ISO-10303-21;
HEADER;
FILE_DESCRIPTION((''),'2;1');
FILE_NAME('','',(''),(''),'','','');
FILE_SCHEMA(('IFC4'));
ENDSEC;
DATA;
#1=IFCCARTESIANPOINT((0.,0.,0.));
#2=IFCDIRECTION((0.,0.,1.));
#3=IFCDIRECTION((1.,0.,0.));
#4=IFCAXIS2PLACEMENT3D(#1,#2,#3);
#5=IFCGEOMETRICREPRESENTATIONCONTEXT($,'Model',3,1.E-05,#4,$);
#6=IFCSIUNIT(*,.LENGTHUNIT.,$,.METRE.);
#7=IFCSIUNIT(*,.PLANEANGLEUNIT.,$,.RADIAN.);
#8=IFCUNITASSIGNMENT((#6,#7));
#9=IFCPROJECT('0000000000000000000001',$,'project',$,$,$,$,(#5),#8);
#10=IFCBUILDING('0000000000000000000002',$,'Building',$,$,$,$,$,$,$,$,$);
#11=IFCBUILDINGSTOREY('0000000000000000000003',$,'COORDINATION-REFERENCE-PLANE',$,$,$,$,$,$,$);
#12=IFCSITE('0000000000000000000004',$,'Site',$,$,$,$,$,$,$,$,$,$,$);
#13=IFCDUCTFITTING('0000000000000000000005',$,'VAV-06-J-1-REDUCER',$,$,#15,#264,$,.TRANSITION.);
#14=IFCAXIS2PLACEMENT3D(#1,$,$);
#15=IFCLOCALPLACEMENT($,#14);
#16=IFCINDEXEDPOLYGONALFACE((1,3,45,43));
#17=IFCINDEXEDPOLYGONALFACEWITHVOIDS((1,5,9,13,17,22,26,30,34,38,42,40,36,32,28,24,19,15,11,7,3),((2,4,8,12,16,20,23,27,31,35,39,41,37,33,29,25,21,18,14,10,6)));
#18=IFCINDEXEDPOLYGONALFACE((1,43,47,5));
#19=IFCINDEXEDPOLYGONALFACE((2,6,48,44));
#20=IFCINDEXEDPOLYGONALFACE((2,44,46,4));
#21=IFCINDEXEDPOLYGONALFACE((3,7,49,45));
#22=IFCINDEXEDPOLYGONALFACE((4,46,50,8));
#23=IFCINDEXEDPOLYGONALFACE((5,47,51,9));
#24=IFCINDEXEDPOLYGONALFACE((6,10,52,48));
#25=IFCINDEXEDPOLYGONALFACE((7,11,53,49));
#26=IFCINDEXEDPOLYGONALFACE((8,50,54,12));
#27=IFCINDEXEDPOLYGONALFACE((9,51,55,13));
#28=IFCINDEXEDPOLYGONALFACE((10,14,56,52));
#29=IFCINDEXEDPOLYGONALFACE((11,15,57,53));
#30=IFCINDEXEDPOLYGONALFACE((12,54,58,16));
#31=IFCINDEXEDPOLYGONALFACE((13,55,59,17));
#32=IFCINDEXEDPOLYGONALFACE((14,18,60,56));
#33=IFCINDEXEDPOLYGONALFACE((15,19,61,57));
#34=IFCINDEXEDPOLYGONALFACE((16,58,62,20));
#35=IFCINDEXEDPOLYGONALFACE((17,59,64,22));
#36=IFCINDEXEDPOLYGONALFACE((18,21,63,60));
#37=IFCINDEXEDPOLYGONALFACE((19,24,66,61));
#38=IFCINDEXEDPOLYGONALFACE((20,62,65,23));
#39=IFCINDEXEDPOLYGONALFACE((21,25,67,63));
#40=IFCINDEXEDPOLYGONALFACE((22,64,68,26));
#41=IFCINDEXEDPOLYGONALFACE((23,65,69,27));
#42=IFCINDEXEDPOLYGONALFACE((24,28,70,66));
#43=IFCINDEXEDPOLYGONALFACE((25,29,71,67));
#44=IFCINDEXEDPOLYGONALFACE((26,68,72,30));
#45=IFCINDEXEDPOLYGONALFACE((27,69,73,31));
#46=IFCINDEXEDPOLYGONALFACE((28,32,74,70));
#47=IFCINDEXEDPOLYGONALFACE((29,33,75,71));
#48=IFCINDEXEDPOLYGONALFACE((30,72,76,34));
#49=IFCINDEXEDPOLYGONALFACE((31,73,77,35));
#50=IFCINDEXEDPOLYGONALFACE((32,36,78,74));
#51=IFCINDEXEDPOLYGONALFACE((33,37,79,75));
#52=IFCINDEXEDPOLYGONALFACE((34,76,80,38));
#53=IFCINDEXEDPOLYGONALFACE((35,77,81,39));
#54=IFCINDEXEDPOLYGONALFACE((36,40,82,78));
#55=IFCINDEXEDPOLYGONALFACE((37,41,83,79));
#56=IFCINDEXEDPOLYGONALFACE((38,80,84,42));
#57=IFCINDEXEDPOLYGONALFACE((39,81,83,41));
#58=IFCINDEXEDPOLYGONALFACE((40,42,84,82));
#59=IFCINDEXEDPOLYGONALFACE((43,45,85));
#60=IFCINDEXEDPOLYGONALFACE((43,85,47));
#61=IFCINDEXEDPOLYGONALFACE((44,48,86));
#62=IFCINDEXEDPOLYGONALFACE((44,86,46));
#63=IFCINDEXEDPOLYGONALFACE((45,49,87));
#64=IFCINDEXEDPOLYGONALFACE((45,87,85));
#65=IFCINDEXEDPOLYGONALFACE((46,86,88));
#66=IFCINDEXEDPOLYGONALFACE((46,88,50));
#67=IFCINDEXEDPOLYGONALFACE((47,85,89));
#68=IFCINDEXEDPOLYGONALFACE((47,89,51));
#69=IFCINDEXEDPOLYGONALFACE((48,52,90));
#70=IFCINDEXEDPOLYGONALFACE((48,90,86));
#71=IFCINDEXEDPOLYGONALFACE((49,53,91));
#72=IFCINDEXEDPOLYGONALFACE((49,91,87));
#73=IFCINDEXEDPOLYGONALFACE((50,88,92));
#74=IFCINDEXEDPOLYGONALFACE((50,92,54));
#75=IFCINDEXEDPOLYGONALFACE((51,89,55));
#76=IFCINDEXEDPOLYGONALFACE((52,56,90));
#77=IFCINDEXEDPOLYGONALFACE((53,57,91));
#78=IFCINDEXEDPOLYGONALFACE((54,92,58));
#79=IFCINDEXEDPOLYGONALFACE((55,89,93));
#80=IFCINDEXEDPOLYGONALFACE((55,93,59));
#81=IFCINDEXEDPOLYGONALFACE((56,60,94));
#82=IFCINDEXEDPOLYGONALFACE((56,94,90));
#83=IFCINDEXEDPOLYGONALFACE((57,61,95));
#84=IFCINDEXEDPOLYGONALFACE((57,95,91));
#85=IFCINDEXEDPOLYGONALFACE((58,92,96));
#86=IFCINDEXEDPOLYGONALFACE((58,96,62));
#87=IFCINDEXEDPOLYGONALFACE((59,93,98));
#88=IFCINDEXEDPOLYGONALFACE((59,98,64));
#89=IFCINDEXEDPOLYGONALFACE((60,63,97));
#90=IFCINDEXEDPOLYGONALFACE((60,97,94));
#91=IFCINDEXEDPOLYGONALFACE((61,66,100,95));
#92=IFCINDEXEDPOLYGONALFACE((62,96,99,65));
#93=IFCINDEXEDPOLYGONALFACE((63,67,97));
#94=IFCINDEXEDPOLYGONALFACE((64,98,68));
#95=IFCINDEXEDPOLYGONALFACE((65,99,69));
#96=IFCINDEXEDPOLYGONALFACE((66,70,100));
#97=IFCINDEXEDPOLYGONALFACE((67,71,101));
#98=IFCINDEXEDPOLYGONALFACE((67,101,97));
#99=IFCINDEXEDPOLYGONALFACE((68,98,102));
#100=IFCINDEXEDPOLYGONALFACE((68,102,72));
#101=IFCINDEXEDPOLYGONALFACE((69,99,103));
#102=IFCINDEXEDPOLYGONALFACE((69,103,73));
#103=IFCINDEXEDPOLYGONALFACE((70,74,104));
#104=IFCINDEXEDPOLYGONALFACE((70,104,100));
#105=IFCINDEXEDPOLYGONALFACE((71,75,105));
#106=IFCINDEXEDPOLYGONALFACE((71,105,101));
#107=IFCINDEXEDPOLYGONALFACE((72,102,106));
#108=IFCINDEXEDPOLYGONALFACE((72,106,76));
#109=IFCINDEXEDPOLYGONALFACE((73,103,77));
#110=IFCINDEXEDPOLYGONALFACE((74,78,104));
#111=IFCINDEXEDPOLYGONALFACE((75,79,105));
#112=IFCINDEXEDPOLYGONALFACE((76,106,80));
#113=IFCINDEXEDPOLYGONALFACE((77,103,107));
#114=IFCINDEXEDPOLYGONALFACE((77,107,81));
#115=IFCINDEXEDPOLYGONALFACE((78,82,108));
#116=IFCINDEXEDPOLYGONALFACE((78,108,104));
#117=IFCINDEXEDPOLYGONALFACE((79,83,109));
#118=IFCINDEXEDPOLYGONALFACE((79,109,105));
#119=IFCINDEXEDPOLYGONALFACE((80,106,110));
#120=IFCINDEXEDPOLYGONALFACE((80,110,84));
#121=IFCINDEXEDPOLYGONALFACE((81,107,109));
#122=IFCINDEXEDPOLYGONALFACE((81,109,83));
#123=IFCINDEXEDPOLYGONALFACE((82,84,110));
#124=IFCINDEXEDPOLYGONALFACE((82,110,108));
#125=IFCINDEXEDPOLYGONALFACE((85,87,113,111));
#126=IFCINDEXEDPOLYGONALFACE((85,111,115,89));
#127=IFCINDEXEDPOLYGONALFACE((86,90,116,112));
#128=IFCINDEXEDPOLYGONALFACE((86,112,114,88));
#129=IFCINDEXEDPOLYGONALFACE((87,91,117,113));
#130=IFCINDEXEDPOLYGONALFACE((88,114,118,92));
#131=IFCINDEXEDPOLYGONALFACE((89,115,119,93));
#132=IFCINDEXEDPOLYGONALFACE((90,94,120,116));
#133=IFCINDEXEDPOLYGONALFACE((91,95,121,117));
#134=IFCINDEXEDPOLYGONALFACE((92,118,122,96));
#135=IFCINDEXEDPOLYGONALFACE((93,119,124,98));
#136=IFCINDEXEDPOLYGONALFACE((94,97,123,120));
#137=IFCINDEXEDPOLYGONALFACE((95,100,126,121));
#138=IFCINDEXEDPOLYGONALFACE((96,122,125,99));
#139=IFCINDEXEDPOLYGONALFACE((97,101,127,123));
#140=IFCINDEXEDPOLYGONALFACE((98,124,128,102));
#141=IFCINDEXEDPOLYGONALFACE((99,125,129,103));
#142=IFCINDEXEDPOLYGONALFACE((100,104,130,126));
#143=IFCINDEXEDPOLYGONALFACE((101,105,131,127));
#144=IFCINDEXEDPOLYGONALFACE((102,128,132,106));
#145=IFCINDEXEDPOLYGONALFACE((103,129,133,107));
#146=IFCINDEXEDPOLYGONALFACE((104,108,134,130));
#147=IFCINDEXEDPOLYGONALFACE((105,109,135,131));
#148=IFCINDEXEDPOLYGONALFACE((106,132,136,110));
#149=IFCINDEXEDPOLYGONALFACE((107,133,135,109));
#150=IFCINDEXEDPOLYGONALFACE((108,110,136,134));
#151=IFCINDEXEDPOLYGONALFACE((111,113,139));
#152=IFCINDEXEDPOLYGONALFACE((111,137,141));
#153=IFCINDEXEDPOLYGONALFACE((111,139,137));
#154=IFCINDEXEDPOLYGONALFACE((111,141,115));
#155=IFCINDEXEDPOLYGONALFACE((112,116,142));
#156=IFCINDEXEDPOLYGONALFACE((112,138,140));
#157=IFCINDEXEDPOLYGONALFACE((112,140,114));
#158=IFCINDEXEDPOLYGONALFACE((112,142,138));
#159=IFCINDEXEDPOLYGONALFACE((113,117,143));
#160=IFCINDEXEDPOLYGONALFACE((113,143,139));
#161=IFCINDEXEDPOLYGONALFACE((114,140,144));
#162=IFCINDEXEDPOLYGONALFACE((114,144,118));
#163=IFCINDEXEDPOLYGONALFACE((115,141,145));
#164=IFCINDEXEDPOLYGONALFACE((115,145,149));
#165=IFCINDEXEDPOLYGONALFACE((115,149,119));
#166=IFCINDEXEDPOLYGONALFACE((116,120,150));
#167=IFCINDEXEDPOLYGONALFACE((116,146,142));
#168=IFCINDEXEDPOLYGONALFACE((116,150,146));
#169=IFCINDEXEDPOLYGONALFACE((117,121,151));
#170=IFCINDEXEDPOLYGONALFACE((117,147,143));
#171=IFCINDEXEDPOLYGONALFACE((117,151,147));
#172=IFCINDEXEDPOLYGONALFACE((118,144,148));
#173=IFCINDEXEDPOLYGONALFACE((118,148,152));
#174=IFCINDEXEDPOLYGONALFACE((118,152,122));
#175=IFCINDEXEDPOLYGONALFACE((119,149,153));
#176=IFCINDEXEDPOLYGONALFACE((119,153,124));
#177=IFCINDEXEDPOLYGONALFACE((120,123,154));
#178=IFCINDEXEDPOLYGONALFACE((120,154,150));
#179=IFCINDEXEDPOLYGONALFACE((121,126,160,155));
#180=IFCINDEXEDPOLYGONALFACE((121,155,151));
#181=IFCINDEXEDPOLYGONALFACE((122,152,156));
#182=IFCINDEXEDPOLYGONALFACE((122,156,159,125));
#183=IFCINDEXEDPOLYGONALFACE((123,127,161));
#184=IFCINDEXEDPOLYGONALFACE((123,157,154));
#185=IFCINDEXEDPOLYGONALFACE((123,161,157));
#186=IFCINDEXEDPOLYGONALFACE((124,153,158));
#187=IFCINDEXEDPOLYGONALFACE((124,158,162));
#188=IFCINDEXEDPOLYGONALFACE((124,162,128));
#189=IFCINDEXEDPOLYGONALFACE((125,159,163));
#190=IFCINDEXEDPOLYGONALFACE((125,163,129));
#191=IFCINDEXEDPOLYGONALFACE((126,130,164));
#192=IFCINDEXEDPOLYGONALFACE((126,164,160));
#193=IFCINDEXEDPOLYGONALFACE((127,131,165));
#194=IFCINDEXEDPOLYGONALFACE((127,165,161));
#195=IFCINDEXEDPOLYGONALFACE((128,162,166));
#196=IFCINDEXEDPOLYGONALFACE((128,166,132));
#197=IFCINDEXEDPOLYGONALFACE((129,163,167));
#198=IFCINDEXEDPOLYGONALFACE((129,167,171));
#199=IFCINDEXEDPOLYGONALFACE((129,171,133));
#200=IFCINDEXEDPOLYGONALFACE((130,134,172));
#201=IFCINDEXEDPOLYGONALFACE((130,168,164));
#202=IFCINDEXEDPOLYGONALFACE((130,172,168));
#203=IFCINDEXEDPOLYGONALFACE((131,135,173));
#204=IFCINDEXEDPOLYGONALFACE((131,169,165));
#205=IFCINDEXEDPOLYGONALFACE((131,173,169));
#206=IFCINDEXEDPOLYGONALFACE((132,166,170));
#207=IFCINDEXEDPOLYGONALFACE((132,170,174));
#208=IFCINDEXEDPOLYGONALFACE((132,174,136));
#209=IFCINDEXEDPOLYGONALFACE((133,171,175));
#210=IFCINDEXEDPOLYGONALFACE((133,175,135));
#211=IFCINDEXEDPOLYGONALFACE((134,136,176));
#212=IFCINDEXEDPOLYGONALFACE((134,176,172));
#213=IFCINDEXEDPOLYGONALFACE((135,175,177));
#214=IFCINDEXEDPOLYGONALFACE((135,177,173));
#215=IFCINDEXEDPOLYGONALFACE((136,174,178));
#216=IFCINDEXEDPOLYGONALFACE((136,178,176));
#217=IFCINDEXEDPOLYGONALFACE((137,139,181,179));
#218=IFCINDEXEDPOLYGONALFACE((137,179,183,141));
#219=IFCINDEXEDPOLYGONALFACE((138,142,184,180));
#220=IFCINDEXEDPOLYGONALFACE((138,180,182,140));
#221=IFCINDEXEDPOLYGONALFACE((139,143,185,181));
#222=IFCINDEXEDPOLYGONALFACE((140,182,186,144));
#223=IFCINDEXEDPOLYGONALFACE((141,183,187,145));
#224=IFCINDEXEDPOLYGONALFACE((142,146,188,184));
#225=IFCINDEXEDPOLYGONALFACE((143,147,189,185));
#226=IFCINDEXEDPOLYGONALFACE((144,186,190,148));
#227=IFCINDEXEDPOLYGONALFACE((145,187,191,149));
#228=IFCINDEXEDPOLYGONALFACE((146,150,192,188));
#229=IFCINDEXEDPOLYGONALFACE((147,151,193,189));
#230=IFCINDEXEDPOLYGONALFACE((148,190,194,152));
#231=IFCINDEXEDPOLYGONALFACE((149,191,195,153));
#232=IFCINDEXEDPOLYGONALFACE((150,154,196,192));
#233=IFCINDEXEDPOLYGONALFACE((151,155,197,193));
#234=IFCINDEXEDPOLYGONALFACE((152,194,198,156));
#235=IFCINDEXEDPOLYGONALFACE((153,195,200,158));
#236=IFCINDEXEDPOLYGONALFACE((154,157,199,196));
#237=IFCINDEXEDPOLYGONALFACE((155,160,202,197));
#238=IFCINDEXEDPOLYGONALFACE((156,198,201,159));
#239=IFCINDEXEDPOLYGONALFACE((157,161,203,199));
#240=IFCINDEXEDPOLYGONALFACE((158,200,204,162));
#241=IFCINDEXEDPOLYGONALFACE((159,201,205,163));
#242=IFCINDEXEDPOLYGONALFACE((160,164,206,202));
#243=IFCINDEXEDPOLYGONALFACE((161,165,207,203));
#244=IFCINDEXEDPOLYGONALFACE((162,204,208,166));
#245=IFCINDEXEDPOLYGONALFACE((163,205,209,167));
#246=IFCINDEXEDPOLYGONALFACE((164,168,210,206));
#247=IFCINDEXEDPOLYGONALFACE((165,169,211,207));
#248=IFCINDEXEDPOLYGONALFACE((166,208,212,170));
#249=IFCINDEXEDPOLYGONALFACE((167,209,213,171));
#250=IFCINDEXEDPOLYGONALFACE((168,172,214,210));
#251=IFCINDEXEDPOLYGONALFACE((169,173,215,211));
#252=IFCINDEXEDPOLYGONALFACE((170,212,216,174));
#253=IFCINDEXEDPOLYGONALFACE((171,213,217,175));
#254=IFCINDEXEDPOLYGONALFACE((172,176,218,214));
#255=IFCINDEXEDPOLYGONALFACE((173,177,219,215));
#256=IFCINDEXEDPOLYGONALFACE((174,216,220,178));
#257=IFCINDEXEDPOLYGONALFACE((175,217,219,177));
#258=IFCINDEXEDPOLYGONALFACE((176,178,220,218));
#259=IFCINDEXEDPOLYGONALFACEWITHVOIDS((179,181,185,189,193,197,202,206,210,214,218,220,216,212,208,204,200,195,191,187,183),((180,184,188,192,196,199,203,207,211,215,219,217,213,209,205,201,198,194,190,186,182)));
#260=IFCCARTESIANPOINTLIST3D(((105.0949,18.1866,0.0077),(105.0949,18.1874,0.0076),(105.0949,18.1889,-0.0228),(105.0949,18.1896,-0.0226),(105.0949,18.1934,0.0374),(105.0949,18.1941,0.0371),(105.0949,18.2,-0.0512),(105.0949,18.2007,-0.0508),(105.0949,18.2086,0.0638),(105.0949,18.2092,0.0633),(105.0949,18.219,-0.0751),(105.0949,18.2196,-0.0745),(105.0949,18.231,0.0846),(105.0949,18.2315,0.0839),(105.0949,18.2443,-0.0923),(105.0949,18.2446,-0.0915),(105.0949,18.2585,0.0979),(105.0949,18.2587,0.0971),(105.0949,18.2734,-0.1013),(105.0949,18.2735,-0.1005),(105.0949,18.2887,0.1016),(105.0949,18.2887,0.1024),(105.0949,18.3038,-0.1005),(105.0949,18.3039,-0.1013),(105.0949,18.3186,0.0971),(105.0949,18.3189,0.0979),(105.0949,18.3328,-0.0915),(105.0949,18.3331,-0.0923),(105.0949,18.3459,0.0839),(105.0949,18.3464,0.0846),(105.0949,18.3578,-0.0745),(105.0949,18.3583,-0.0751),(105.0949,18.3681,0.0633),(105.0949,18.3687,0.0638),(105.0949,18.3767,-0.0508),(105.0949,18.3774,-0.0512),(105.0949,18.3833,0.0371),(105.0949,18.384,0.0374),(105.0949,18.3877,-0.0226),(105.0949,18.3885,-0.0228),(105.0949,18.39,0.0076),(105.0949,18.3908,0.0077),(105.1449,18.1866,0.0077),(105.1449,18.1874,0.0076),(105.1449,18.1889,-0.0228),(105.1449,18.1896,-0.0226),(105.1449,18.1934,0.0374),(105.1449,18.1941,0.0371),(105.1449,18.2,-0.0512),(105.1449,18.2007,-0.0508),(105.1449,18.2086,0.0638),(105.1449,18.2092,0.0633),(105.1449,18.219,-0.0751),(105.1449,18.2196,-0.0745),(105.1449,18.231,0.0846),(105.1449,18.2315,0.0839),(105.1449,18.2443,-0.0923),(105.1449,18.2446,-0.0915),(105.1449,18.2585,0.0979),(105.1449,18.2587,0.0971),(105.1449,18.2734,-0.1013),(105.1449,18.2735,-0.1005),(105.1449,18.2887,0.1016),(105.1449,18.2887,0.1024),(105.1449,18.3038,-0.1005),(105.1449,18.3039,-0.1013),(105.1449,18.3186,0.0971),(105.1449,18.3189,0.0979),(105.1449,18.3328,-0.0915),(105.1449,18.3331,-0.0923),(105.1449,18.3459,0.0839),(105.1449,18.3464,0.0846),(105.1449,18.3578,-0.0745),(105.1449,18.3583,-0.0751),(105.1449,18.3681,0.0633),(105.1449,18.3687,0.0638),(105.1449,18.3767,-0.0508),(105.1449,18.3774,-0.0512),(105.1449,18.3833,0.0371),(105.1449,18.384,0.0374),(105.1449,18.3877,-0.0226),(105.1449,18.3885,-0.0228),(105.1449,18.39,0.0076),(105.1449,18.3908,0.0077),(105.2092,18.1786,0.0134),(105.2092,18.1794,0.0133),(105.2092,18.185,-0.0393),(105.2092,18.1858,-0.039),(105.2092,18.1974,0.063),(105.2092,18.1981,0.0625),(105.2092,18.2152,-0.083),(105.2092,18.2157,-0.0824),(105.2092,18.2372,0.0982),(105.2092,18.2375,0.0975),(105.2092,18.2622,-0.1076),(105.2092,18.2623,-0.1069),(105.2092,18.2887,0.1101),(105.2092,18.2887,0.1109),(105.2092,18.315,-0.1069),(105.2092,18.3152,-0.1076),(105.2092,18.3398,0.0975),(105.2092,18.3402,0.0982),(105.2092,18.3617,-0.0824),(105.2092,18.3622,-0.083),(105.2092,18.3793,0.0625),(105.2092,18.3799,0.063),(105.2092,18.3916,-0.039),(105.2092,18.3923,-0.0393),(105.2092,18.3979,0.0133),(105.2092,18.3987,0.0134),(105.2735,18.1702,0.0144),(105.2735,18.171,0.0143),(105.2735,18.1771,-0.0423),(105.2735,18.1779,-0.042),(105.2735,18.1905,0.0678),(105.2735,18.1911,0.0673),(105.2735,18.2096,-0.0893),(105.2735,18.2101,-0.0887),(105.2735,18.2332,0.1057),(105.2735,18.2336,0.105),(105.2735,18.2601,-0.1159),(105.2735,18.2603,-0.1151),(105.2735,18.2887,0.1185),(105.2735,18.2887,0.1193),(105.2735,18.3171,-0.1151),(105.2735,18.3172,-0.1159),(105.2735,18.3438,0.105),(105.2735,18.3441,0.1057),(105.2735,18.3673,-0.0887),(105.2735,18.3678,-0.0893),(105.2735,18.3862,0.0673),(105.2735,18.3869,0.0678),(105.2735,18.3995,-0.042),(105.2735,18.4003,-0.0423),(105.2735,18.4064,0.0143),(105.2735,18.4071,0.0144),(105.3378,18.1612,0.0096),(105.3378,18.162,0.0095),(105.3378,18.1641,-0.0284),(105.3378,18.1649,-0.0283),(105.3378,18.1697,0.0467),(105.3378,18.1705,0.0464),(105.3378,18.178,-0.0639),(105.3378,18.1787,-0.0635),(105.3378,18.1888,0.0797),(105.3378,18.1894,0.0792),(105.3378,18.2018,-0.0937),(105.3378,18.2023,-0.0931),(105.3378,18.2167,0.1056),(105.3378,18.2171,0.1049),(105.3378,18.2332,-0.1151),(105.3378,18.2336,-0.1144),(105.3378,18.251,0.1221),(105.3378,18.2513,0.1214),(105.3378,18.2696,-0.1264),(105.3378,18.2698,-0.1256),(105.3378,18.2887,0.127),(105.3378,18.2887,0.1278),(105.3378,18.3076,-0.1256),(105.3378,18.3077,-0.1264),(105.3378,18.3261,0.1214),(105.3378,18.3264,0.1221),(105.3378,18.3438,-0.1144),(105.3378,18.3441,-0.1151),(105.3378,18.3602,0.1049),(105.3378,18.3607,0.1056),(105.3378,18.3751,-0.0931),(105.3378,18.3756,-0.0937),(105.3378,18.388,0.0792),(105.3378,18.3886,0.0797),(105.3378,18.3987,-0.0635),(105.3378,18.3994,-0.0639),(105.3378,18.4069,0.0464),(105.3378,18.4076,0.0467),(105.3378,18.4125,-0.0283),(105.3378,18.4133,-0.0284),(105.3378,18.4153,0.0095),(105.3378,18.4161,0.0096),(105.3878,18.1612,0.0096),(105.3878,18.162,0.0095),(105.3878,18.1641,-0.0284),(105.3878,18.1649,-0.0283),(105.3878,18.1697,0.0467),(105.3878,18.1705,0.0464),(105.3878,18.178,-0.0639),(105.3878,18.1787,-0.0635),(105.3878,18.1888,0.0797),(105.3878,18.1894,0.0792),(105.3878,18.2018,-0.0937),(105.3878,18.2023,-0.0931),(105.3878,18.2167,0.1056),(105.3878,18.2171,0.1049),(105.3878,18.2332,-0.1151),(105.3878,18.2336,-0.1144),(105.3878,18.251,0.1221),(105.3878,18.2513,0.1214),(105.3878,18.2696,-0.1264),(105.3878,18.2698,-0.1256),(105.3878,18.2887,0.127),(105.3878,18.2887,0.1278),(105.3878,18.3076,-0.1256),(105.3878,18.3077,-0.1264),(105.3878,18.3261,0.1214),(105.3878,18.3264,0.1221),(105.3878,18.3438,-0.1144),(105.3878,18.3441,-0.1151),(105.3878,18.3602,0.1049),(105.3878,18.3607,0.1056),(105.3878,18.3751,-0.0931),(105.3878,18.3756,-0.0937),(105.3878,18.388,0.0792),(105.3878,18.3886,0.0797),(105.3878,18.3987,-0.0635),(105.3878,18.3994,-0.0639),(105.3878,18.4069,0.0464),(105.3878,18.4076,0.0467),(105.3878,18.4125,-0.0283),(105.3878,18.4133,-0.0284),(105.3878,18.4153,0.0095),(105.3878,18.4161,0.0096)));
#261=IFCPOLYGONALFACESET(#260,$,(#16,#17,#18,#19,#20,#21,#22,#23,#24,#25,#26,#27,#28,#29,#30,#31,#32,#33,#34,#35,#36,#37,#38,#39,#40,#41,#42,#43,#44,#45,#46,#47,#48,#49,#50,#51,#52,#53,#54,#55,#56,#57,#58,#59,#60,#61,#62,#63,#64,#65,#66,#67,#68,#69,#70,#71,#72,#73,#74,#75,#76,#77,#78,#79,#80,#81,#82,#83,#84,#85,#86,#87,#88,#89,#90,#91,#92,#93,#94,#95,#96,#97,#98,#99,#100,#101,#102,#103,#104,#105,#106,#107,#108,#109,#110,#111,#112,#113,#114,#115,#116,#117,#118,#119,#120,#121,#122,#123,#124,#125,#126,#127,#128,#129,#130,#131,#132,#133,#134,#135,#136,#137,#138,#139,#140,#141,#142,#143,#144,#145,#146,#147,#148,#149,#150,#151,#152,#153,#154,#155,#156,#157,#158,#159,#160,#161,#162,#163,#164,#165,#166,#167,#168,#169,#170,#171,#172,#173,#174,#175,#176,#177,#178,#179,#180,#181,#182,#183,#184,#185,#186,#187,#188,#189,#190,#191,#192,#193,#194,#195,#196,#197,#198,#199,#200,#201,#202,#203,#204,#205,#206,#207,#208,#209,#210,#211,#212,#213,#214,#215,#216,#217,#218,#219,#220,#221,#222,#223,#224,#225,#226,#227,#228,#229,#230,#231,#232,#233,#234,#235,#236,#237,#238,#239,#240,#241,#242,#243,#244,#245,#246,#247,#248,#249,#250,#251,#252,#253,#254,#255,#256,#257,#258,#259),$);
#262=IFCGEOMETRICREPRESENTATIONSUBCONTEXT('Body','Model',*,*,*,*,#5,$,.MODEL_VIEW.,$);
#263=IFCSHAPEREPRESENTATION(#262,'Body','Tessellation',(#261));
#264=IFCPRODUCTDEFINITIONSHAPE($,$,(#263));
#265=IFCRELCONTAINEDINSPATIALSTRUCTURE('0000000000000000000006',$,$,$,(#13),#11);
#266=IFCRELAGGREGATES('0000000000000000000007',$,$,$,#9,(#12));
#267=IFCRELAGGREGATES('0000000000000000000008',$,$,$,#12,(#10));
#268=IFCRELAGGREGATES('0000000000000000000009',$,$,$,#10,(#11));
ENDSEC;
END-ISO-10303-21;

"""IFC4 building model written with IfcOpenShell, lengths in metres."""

from ifc_helpers import new_model, entity, si_unit, frame, origin_with_axes, place, context, subcontext, project, spatial, element, save


model = new_model("IFC4")

# Units and contexts
model_context_1 = context("Model", 3, precision=1e-05, world=origin_with_axes())
body_context_1 = subcontext(model_context_1, "Body", "Model", "MODEL_VIEW")
ifc_project = project(units=[si_unit("LENGTHUNIT", "METRE"), si_unit("PLANEANGLEUNIT", "RADIAN")], contexts=[model_context_1])

# Site, building, storey
site = spatial("IfcSite", under=ifc_project, Name="Site")
building = spatial("IfcBuilding", under=site, Name="Building")
storey = spatial("IfcBuildingStorey", under=building, Name="COORDINATION-REFERENCE-PLANE")

# Duct fitting
for number, where, z_axis, x_axis, name in (
    (1, (105.3878, 18.2887, 0.0), (0.0, -1.0, 0.0), (0.0, 0.0, 1.0), "VAV-06-J-1-REDUCER"),
):
    element("IfcDuctFitting", number, at=place(None, frame(where, z_axis=z_axis, x_axis=x_axis)), inside=storey, Name=name, PredefinedType="TRANSITION", context=body_context_1, shape_type="SweptSolid", body=[
        entity("IfcRevolvedAreaSolid", entity("IfcArbitraryClosedProfileDef", "AREA", None, entity("IfcPolyline", [entity("IfcCartesianPoint", [0.1278, 0.0]), entity("IfcCartesianPoint", [0.1278, 0.05]), entity("IfcCartesianPoint", [0.1024, 0.2429]), entity("IfcCartesianPoint", [0.1024, 0.2929]), entity("IfcCartesianPoint", [0.1016, 0.2929]), entity("IfcCartesianPoint", [0.1016, 0.2429]), entity("IfcCartesianPoint", [0.127, 0.05]), entity("IfcCartesianPoint", [0.127, 0.0]), entity("IfcCartesianPoint", [0.1278, 0.0])])), entity("IfcAxis2Placement3D", entity("IfcCartesianPoint", [0.0, 0.0, 0.0])), entity("IfcAxis1Placement", entity("IfcCartesianPoint", [0.0, 0.0, 0.0]), entity("IfcDirection", [0.0, 1.0, 0.0])), 6.283185),
    ])

save(model, "model.ifc")
